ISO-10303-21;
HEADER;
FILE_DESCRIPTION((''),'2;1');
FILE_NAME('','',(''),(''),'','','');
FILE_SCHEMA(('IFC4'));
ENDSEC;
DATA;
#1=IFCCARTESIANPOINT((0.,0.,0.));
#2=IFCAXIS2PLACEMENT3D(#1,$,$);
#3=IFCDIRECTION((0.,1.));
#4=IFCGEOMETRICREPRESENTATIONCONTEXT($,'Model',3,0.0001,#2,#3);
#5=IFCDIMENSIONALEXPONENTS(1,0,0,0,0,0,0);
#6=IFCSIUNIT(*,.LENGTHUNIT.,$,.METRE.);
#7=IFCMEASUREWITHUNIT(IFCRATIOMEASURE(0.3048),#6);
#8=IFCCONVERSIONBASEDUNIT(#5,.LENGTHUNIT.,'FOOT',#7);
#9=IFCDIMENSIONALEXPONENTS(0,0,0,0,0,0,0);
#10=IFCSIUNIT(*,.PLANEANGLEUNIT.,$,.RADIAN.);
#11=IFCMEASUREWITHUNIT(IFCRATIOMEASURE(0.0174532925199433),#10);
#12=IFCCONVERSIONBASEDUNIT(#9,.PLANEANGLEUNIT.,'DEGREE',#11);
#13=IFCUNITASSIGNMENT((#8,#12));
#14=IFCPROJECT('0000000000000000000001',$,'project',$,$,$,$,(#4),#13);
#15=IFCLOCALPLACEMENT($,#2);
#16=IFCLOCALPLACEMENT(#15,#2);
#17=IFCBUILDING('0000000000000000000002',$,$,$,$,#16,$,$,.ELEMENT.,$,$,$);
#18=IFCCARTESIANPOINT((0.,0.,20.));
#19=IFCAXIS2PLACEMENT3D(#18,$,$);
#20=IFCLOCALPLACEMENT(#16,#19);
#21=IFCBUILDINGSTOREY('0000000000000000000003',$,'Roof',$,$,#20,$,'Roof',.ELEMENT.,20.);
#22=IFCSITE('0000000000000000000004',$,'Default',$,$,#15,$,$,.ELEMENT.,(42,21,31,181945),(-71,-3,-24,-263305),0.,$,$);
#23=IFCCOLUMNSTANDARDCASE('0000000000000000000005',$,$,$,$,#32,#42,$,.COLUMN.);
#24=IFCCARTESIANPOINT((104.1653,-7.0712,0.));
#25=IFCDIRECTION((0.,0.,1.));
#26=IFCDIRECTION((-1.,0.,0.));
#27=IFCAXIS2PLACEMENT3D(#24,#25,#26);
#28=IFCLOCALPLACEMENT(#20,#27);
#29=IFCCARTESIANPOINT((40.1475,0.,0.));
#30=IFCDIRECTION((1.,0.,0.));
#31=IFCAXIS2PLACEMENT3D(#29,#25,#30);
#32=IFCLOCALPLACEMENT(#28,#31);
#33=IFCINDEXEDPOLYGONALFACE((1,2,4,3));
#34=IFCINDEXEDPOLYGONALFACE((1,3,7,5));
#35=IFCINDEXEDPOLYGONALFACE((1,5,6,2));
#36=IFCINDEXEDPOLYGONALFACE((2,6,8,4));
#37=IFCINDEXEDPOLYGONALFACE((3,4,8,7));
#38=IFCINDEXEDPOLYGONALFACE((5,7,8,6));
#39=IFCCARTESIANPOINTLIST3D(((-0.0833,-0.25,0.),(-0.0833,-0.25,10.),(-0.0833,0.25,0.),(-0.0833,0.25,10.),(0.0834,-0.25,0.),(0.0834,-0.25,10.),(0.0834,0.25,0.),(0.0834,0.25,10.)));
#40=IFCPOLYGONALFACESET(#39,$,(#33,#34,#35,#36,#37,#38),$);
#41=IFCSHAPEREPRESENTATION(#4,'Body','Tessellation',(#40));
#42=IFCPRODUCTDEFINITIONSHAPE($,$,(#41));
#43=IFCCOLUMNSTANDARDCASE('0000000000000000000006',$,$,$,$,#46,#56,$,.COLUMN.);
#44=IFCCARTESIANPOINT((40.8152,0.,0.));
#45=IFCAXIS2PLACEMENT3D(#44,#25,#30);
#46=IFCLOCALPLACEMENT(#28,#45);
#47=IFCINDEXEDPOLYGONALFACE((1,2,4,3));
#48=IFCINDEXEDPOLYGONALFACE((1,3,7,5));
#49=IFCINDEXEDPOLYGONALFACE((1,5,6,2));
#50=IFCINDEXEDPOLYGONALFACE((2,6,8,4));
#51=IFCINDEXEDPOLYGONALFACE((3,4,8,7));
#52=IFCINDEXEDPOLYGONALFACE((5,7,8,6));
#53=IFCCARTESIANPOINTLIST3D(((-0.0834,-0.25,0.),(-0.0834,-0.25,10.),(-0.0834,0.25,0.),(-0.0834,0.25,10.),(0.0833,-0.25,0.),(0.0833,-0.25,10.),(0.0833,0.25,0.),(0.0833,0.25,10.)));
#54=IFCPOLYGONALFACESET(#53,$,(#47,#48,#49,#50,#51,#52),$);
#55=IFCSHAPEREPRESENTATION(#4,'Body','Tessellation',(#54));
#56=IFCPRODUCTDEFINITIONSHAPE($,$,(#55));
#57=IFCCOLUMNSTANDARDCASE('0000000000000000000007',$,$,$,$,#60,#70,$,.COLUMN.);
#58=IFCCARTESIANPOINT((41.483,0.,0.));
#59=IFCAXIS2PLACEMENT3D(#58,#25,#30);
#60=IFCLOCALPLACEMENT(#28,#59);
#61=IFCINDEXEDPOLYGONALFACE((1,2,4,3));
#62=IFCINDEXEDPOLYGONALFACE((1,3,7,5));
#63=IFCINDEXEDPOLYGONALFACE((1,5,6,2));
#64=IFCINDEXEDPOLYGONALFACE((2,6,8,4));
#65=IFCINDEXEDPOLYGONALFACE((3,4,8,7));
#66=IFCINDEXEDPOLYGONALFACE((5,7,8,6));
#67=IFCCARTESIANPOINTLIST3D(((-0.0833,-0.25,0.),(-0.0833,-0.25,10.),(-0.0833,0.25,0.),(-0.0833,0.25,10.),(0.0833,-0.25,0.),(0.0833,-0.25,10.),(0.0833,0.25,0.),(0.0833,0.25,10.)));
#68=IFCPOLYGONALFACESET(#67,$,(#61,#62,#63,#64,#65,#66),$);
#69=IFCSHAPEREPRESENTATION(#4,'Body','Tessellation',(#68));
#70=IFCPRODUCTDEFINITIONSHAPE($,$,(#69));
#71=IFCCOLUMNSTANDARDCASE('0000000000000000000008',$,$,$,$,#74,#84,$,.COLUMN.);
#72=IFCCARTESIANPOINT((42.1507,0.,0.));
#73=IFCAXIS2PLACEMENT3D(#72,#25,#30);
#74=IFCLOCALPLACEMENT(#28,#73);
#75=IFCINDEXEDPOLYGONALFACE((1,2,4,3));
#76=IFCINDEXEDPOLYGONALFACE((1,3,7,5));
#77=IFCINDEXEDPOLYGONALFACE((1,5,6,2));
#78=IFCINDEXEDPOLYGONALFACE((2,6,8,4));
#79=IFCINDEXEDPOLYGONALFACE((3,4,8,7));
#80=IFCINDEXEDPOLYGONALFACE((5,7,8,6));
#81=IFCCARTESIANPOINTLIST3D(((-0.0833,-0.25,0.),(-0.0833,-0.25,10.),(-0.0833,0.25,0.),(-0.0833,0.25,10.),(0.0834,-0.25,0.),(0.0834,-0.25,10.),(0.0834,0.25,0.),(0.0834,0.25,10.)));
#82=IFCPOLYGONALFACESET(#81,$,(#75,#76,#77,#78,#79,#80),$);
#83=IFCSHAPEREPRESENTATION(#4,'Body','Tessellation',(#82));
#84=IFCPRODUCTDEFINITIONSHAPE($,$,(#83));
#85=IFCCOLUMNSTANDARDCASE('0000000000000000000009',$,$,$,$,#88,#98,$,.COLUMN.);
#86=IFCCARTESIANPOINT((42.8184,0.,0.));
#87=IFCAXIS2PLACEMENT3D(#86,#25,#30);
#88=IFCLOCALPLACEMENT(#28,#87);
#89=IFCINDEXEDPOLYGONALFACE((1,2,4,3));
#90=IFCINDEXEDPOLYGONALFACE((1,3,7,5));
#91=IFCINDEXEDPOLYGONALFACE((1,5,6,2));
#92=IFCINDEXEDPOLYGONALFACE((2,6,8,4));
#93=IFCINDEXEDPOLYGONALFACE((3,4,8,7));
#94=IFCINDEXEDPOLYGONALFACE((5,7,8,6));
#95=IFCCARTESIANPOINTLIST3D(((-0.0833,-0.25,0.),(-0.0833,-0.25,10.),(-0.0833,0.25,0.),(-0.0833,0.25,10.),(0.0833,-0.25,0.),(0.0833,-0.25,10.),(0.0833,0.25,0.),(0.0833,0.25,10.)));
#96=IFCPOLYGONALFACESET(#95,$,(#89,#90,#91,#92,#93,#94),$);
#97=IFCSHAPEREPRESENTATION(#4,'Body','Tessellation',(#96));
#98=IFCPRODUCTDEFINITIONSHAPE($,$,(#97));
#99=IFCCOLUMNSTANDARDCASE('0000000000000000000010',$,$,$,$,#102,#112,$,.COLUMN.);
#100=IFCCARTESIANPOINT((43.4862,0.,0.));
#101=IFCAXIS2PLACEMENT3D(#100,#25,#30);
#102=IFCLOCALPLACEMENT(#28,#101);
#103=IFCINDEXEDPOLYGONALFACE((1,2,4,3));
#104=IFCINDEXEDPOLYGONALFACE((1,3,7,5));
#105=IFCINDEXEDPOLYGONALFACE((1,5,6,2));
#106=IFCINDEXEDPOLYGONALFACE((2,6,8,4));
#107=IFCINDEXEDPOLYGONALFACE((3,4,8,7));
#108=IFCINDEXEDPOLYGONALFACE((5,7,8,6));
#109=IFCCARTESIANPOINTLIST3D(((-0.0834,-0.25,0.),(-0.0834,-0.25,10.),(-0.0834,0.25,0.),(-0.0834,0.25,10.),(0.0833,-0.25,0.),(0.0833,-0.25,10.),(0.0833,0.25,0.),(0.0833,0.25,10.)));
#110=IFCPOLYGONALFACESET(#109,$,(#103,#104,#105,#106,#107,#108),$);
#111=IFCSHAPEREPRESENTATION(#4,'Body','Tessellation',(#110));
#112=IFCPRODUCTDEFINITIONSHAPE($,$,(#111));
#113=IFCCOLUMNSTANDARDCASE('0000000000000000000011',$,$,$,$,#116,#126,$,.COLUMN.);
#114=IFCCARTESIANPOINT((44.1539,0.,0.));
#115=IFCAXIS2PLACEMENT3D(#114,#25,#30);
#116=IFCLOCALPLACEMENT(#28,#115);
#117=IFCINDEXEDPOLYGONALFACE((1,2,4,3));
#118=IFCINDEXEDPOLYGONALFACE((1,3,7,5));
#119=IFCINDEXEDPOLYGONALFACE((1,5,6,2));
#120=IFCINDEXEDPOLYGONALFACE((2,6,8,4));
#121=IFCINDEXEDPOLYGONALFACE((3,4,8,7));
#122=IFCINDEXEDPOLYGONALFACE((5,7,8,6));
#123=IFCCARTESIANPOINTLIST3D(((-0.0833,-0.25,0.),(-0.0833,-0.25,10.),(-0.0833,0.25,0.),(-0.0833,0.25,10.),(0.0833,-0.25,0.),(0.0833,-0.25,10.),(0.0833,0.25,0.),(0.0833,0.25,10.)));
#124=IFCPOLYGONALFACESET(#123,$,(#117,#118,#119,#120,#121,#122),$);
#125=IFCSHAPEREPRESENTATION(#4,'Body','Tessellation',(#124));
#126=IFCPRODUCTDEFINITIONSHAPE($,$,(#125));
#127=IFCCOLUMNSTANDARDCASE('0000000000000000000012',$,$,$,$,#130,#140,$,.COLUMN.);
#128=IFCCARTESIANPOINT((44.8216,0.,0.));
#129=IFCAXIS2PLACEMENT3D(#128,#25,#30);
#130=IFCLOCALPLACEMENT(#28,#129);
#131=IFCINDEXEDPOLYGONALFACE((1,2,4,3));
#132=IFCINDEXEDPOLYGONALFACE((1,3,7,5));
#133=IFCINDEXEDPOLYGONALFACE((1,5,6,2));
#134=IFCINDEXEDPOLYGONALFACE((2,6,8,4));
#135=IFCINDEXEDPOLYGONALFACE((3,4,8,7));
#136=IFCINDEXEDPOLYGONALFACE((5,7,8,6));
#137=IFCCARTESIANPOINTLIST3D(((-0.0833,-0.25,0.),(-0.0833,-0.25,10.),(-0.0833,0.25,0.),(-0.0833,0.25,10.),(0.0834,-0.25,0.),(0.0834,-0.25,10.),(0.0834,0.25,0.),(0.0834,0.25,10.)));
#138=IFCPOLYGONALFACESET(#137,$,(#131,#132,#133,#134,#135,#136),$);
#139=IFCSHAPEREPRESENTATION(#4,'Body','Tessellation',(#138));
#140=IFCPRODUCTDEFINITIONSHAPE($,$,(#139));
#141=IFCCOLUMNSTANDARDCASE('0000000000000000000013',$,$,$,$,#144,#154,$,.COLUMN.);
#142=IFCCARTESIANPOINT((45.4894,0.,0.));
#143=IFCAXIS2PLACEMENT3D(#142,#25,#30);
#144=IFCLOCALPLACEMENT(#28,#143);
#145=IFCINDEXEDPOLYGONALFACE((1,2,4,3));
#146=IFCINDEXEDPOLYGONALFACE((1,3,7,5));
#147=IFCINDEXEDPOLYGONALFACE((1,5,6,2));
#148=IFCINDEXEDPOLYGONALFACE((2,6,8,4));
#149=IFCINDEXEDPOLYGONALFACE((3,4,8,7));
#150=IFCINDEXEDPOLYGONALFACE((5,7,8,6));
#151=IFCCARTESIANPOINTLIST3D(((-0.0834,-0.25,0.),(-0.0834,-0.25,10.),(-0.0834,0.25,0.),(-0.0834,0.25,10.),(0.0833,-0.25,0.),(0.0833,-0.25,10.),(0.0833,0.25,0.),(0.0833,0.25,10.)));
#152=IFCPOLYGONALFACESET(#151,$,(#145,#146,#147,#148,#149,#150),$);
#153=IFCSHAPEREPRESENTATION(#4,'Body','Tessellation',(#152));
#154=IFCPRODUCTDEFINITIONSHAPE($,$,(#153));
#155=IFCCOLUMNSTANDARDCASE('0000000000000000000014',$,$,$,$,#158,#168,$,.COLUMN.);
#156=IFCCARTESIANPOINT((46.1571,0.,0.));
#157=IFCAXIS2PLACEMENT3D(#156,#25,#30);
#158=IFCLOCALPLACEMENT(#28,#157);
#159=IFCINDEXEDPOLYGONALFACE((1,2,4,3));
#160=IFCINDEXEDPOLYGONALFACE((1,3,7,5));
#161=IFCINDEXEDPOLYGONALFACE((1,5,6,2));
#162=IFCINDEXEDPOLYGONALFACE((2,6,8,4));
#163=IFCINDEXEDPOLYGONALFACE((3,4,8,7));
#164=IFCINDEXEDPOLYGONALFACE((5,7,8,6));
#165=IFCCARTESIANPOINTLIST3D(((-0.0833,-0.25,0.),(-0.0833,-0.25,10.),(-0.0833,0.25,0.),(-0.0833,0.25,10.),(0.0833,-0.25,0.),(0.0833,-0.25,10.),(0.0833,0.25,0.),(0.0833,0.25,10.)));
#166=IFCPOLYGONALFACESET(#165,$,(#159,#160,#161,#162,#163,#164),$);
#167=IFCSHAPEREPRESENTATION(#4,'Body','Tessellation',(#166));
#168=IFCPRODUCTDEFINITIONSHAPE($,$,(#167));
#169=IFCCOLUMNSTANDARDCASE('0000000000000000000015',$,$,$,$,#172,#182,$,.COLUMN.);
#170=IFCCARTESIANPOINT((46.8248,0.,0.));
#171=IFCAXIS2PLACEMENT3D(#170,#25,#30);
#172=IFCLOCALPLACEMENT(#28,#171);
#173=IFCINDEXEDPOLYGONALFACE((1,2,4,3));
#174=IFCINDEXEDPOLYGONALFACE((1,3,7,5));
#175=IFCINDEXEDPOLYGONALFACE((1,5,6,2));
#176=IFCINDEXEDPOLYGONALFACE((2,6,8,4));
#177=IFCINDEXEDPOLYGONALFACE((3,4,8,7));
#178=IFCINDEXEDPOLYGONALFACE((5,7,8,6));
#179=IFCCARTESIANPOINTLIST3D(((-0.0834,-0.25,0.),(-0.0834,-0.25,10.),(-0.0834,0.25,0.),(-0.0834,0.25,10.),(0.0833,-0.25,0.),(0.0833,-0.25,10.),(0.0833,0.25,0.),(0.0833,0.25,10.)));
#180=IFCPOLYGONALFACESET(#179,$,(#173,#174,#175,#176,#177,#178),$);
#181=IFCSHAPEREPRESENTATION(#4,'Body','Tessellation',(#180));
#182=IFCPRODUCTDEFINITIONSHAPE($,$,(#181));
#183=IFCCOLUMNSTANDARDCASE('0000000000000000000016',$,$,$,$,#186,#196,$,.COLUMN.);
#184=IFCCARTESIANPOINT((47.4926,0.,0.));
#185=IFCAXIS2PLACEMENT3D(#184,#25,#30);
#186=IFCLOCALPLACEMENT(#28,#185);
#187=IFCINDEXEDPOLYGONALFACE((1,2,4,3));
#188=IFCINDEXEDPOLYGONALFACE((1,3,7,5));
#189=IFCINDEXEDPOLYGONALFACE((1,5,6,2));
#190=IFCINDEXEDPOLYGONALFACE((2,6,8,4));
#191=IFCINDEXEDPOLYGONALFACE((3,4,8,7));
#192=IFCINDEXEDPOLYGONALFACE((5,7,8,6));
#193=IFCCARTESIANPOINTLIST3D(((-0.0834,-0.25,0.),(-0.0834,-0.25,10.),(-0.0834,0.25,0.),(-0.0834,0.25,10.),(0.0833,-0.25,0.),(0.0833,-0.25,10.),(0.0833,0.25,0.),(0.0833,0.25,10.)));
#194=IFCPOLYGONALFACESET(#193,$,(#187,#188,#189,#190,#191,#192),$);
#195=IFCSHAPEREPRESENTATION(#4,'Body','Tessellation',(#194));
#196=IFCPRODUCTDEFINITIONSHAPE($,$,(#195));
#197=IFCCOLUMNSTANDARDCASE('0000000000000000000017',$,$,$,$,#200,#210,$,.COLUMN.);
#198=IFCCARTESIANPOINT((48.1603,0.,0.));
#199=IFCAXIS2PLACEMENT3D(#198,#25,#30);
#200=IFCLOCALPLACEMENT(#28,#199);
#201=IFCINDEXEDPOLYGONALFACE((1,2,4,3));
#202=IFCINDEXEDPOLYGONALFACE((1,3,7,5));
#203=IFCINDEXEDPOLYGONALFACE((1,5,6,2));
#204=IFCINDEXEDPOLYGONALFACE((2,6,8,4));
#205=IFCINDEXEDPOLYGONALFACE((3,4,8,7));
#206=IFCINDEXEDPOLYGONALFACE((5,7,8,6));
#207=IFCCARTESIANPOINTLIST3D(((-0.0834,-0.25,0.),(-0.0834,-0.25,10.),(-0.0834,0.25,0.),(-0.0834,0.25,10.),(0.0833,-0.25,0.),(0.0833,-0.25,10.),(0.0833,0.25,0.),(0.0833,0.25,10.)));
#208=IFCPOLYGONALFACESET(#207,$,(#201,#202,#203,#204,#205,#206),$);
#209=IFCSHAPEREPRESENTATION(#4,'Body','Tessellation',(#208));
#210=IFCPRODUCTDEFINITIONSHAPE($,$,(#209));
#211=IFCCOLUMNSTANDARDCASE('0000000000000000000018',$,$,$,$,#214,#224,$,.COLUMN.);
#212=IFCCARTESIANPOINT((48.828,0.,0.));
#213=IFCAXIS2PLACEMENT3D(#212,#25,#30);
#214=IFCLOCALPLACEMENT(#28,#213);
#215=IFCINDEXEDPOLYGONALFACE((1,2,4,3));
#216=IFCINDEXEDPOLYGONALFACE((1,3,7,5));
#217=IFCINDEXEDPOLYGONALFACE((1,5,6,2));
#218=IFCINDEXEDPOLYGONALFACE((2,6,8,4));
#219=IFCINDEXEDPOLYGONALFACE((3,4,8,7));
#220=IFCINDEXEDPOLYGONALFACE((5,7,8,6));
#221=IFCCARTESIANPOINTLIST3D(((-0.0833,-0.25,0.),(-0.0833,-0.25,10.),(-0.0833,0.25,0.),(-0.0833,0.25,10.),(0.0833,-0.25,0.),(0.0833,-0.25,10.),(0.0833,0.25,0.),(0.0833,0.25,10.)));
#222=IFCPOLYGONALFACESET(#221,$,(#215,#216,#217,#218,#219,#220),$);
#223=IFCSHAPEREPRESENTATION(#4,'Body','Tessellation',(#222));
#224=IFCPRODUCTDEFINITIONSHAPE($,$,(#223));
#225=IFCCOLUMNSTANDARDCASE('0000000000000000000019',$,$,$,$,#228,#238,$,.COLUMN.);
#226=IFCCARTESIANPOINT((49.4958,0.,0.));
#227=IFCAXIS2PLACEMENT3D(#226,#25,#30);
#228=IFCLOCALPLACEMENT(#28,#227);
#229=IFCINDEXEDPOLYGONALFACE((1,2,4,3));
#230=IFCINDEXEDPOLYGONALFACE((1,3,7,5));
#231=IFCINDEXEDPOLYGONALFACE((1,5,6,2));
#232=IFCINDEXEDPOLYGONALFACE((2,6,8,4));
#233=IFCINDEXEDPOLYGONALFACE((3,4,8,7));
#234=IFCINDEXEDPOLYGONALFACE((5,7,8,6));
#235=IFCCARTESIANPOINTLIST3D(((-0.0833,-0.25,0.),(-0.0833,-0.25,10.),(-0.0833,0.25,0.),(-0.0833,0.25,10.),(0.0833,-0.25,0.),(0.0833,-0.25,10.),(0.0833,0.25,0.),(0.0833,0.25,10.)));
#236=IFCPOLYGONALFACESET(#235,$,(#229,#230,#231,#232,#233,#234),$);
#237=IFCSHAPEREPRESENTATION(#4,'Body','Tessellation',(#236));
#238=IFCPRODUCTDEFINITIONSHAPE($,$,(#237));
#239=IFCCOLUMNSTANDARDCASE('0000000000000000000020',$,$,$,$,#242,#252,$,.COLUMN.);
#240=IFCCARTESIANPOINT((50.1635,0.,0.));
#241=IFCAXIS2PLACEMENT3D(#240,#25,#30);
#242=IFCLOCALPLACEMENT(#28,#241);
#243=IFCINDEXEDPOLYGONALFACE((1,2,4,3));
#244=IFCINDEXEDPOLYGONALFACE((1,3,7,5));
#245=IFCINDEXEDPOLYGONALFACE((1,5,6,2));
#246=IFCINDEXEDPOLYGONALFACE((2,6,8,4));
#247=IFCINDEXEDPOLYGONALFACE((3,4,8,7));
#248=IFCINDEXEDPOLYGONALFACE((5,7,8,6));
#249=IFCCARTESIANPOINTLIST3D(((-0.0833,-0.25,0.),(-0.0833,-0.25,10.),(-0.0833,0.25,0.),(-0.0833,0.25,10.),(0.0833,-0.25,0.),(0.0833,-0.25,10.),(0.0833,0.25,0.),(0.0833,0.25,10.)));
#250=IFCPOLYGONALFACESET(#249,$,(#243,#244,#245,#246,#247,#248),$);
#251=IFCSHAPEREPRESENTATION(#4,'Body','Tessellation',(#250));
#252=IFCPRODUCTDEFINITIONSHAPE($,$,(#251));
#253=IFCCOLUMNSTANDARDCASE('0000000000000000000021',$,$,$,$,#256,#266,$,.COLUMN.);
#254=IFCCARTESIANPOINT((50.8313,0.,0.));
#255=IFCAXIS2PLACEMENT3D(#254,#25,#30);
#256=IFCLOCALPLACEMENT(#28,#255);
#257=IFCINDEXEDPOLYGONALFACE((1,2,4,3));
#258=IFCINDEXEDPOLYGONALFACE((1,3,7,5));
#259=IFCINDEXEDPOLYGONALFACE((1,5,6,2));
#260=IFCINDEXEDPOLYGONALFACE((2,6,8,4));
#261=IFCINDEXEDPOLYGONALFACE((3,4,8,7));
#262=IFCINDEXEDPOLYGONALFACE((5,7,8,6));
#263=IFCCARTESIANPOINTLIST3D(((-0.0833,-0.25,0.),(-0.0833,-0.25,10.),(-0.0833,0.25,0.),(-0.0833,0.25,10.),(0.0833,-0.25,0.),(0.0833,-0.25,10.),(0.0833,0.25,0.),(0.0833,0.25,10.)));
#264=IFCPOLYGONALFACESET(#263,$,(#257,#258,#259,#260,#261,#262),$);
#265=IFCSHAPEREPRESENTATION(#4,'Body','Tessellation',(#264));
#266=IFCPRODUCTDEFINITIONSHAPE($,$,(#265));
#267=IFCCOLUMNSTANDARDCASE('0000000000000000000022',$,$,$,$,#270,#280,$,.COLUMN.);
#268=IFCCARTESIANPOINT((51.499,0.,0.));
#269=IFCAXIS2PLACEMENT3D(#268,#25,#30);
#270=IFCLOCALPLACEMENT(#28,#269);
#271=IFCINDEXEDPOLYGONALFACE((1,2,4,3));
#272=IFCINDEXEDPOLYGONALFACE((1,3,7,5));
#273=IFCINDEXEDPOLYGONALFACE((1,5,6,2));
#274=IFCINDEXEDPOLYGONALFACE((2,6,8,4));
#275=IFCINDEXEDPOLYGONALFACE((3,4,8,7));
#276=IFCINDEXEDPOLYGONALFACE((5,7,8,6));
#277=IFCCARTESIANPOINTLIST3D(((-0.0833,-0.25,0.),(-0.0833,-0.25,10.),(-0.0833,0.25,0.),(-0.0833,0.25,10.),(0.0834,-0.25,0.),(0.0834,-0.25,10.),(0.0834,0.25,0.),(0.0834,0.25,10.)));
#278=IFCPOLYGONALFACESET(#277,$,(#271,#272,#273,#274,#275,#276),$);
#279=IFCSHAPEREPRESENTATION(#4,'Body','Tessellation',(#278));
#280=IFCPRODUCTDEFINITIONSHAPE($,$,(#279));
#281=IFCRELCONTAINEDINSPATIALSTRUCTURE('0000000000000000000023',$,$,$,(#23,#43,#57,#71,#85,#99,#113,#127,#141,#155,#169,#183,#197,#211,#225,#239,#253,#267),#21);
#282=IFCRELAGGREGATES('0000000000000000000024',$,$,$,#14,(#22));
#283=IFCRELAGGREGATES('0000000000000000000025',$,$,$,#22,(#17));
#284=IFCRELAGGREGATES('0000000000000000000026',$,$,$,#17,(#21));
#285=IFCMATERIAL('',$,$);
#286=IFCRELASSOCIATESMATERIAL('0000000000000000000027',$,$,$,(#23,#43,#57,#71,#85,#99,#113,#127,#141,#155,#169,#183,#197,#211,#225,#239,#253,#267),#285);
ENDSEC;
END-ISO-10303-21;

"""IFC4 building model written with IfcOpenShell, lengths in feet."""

from ifc_helpers import new_model, entity, si_unit, converted_unit, direction, frame, origin, place, context, project, spatial, rectangle, extrude, material, element, save


model = new_model("IFC4")

# Units and contexts
model_context = context("Model", 3, precision=0.0001, world=origin(), true_north=direction((0.0, 1.0)))
ifc_project = project(units=[converted_unit("LENGTHUNIT", "FOOT", entity("IfcRatioMeasure", 0.3048), si_unit("LENGTHUNIT", "METRE"), dimensions=[1, 0, 0, 0, 0, 0, 0]), converted_unit("PLANEANGLEUNIT", "DEGREE", entity("IfcRatioMeasure", 0.0174532925199433), si_unit("PLANEANGLEUNIT", "RADIAN"), dimensions=[0, 0, 0, 0, 0, 0, 0])], contexts=[model_context])

# Site, building, storey
site_placement = place(None, origin())
site = spatial("IfcSite", under=ifc_project, at=site_placement, Name="Default", CompositionType="ELEMENT", RefLatitude=(42, 21, 31, 181945), RefLongitude=(-71, -3, -24, -263305), RefElevation=0.0)
building_placement = place(site_placement, origin())
building = spatial("IfcBuilding", under=site, at=building_placement, CompositionType="ELEMENT")
storey_placement = place(building_placement, frame((0.0, 0.0, 20.0)))
storey = spatial("IfcBuildingStorey", under=building, at=storey_placement, Name="Roof", LongName="Roof", CompositionType="ELEMENT", Elevation=20.0)

# Columns
ifc_material_1 = material(Name="")
placement_1 = place(storey_placement, frame((104.1653, -7.0712, 0.0), z_axis=(0.0, 0.0, 1.0), x_axis=(-1.0, 0.0, 0.0)))
for number, where, z_axis, x_axis in (
    (1, (40.1475, 0.0, 0.0), (0.0, 0.0, 1.0), (1.0, 0.0, 0.0)),
    (2, (40.8152, 0.0, 0.0), (0.0, 0.0, 1.0), (1.0, 0.0, 0.0)),
    (3, (41.483, 0.0, 0.0), (0.0, 0.0, 1.0), (1.0, 0.0, 0.0)),
    (4, (42.1507, 0.0, 0.0), (0.0, 0.0, 1.0), (1.0, 0.0, 0.0)),
    (5, (42.8184, 0.0, 0.0), (0.0, 0.0, 1.0), (1.0, 0.0, 0.0)),
    (6, (43.4862, 0.0, 0.0), (0.0, 0.0, 1.0), (1.0, 0.0, 0.0)),
    (7, (44.1539, 0.0, 0.0), (0.0, 0.0, 1.0), (1.0, 0.0, 0.0)),
    (8, (44.8216, 0.0, 0.0), (0.0, 0.0, 1.0), (1.0, 0.0, 0.0)),
    (9, (45.4894, 0.0, 0.0), (0.0, 0.0, 1.0), (1.0, 0.0, 0.0)),
    (10, (46.1571, 0.0, 0.0), (0.0, 0.0, 1.0), (1.0, 0.0, 0.0)),
    (11, (46.8248, 0.0, 0.0), (0.0, 0.0, 1.0), (1.0, 0.0, 0.0)),
    (12, (47.4926, 0.0, 0.0), (0.0, 0.0, 1.0), (1.0, 0.0, 0.0)),
    (13, (48.1603, 0.0, 0.0), (0.0, 0.0, 1.0), (1.0, 0.0, 0.0)),
    (14, (48.828, 0.0, 0.0), (0.0, 0.0, 1.0), (1.0, 0.0, 0.0)),
    (15, (49.4958, 0.0, 0.0), (0.0, 0.0, 1.0), (1.0, 0.0, 0.0)),
    (16, (50.1635, 0.0, 0.0), (0.0, 0.0, 1.0), (1.0, 0.0, 0.0)),
    (17, (50.8313, 0.0, 0.0), (0.0, 0.0, 1.0), (1.0, 0.0, 0.0)),
    (18, (51.499, 0.0, 0.0), (0.0, 0.0, 1.0), (1.0, 0.0, 0.0)),
):
    element("IfcColumnStandardCase", number, at=place(placement_1, frame(where, z_axis=z_axis, x_axis=x_axis)), inside=storey, material=ifc_material_1, PredefinedType="COLUMN", context=model_context, shape_type="SweptSolid", body=[
        extrude(rectangle(XDim=0.1667, YDim=0.5), origin(), (0.0, 0.0, 1.0), 10.0),
    ])

save(model, "model.ifc")
